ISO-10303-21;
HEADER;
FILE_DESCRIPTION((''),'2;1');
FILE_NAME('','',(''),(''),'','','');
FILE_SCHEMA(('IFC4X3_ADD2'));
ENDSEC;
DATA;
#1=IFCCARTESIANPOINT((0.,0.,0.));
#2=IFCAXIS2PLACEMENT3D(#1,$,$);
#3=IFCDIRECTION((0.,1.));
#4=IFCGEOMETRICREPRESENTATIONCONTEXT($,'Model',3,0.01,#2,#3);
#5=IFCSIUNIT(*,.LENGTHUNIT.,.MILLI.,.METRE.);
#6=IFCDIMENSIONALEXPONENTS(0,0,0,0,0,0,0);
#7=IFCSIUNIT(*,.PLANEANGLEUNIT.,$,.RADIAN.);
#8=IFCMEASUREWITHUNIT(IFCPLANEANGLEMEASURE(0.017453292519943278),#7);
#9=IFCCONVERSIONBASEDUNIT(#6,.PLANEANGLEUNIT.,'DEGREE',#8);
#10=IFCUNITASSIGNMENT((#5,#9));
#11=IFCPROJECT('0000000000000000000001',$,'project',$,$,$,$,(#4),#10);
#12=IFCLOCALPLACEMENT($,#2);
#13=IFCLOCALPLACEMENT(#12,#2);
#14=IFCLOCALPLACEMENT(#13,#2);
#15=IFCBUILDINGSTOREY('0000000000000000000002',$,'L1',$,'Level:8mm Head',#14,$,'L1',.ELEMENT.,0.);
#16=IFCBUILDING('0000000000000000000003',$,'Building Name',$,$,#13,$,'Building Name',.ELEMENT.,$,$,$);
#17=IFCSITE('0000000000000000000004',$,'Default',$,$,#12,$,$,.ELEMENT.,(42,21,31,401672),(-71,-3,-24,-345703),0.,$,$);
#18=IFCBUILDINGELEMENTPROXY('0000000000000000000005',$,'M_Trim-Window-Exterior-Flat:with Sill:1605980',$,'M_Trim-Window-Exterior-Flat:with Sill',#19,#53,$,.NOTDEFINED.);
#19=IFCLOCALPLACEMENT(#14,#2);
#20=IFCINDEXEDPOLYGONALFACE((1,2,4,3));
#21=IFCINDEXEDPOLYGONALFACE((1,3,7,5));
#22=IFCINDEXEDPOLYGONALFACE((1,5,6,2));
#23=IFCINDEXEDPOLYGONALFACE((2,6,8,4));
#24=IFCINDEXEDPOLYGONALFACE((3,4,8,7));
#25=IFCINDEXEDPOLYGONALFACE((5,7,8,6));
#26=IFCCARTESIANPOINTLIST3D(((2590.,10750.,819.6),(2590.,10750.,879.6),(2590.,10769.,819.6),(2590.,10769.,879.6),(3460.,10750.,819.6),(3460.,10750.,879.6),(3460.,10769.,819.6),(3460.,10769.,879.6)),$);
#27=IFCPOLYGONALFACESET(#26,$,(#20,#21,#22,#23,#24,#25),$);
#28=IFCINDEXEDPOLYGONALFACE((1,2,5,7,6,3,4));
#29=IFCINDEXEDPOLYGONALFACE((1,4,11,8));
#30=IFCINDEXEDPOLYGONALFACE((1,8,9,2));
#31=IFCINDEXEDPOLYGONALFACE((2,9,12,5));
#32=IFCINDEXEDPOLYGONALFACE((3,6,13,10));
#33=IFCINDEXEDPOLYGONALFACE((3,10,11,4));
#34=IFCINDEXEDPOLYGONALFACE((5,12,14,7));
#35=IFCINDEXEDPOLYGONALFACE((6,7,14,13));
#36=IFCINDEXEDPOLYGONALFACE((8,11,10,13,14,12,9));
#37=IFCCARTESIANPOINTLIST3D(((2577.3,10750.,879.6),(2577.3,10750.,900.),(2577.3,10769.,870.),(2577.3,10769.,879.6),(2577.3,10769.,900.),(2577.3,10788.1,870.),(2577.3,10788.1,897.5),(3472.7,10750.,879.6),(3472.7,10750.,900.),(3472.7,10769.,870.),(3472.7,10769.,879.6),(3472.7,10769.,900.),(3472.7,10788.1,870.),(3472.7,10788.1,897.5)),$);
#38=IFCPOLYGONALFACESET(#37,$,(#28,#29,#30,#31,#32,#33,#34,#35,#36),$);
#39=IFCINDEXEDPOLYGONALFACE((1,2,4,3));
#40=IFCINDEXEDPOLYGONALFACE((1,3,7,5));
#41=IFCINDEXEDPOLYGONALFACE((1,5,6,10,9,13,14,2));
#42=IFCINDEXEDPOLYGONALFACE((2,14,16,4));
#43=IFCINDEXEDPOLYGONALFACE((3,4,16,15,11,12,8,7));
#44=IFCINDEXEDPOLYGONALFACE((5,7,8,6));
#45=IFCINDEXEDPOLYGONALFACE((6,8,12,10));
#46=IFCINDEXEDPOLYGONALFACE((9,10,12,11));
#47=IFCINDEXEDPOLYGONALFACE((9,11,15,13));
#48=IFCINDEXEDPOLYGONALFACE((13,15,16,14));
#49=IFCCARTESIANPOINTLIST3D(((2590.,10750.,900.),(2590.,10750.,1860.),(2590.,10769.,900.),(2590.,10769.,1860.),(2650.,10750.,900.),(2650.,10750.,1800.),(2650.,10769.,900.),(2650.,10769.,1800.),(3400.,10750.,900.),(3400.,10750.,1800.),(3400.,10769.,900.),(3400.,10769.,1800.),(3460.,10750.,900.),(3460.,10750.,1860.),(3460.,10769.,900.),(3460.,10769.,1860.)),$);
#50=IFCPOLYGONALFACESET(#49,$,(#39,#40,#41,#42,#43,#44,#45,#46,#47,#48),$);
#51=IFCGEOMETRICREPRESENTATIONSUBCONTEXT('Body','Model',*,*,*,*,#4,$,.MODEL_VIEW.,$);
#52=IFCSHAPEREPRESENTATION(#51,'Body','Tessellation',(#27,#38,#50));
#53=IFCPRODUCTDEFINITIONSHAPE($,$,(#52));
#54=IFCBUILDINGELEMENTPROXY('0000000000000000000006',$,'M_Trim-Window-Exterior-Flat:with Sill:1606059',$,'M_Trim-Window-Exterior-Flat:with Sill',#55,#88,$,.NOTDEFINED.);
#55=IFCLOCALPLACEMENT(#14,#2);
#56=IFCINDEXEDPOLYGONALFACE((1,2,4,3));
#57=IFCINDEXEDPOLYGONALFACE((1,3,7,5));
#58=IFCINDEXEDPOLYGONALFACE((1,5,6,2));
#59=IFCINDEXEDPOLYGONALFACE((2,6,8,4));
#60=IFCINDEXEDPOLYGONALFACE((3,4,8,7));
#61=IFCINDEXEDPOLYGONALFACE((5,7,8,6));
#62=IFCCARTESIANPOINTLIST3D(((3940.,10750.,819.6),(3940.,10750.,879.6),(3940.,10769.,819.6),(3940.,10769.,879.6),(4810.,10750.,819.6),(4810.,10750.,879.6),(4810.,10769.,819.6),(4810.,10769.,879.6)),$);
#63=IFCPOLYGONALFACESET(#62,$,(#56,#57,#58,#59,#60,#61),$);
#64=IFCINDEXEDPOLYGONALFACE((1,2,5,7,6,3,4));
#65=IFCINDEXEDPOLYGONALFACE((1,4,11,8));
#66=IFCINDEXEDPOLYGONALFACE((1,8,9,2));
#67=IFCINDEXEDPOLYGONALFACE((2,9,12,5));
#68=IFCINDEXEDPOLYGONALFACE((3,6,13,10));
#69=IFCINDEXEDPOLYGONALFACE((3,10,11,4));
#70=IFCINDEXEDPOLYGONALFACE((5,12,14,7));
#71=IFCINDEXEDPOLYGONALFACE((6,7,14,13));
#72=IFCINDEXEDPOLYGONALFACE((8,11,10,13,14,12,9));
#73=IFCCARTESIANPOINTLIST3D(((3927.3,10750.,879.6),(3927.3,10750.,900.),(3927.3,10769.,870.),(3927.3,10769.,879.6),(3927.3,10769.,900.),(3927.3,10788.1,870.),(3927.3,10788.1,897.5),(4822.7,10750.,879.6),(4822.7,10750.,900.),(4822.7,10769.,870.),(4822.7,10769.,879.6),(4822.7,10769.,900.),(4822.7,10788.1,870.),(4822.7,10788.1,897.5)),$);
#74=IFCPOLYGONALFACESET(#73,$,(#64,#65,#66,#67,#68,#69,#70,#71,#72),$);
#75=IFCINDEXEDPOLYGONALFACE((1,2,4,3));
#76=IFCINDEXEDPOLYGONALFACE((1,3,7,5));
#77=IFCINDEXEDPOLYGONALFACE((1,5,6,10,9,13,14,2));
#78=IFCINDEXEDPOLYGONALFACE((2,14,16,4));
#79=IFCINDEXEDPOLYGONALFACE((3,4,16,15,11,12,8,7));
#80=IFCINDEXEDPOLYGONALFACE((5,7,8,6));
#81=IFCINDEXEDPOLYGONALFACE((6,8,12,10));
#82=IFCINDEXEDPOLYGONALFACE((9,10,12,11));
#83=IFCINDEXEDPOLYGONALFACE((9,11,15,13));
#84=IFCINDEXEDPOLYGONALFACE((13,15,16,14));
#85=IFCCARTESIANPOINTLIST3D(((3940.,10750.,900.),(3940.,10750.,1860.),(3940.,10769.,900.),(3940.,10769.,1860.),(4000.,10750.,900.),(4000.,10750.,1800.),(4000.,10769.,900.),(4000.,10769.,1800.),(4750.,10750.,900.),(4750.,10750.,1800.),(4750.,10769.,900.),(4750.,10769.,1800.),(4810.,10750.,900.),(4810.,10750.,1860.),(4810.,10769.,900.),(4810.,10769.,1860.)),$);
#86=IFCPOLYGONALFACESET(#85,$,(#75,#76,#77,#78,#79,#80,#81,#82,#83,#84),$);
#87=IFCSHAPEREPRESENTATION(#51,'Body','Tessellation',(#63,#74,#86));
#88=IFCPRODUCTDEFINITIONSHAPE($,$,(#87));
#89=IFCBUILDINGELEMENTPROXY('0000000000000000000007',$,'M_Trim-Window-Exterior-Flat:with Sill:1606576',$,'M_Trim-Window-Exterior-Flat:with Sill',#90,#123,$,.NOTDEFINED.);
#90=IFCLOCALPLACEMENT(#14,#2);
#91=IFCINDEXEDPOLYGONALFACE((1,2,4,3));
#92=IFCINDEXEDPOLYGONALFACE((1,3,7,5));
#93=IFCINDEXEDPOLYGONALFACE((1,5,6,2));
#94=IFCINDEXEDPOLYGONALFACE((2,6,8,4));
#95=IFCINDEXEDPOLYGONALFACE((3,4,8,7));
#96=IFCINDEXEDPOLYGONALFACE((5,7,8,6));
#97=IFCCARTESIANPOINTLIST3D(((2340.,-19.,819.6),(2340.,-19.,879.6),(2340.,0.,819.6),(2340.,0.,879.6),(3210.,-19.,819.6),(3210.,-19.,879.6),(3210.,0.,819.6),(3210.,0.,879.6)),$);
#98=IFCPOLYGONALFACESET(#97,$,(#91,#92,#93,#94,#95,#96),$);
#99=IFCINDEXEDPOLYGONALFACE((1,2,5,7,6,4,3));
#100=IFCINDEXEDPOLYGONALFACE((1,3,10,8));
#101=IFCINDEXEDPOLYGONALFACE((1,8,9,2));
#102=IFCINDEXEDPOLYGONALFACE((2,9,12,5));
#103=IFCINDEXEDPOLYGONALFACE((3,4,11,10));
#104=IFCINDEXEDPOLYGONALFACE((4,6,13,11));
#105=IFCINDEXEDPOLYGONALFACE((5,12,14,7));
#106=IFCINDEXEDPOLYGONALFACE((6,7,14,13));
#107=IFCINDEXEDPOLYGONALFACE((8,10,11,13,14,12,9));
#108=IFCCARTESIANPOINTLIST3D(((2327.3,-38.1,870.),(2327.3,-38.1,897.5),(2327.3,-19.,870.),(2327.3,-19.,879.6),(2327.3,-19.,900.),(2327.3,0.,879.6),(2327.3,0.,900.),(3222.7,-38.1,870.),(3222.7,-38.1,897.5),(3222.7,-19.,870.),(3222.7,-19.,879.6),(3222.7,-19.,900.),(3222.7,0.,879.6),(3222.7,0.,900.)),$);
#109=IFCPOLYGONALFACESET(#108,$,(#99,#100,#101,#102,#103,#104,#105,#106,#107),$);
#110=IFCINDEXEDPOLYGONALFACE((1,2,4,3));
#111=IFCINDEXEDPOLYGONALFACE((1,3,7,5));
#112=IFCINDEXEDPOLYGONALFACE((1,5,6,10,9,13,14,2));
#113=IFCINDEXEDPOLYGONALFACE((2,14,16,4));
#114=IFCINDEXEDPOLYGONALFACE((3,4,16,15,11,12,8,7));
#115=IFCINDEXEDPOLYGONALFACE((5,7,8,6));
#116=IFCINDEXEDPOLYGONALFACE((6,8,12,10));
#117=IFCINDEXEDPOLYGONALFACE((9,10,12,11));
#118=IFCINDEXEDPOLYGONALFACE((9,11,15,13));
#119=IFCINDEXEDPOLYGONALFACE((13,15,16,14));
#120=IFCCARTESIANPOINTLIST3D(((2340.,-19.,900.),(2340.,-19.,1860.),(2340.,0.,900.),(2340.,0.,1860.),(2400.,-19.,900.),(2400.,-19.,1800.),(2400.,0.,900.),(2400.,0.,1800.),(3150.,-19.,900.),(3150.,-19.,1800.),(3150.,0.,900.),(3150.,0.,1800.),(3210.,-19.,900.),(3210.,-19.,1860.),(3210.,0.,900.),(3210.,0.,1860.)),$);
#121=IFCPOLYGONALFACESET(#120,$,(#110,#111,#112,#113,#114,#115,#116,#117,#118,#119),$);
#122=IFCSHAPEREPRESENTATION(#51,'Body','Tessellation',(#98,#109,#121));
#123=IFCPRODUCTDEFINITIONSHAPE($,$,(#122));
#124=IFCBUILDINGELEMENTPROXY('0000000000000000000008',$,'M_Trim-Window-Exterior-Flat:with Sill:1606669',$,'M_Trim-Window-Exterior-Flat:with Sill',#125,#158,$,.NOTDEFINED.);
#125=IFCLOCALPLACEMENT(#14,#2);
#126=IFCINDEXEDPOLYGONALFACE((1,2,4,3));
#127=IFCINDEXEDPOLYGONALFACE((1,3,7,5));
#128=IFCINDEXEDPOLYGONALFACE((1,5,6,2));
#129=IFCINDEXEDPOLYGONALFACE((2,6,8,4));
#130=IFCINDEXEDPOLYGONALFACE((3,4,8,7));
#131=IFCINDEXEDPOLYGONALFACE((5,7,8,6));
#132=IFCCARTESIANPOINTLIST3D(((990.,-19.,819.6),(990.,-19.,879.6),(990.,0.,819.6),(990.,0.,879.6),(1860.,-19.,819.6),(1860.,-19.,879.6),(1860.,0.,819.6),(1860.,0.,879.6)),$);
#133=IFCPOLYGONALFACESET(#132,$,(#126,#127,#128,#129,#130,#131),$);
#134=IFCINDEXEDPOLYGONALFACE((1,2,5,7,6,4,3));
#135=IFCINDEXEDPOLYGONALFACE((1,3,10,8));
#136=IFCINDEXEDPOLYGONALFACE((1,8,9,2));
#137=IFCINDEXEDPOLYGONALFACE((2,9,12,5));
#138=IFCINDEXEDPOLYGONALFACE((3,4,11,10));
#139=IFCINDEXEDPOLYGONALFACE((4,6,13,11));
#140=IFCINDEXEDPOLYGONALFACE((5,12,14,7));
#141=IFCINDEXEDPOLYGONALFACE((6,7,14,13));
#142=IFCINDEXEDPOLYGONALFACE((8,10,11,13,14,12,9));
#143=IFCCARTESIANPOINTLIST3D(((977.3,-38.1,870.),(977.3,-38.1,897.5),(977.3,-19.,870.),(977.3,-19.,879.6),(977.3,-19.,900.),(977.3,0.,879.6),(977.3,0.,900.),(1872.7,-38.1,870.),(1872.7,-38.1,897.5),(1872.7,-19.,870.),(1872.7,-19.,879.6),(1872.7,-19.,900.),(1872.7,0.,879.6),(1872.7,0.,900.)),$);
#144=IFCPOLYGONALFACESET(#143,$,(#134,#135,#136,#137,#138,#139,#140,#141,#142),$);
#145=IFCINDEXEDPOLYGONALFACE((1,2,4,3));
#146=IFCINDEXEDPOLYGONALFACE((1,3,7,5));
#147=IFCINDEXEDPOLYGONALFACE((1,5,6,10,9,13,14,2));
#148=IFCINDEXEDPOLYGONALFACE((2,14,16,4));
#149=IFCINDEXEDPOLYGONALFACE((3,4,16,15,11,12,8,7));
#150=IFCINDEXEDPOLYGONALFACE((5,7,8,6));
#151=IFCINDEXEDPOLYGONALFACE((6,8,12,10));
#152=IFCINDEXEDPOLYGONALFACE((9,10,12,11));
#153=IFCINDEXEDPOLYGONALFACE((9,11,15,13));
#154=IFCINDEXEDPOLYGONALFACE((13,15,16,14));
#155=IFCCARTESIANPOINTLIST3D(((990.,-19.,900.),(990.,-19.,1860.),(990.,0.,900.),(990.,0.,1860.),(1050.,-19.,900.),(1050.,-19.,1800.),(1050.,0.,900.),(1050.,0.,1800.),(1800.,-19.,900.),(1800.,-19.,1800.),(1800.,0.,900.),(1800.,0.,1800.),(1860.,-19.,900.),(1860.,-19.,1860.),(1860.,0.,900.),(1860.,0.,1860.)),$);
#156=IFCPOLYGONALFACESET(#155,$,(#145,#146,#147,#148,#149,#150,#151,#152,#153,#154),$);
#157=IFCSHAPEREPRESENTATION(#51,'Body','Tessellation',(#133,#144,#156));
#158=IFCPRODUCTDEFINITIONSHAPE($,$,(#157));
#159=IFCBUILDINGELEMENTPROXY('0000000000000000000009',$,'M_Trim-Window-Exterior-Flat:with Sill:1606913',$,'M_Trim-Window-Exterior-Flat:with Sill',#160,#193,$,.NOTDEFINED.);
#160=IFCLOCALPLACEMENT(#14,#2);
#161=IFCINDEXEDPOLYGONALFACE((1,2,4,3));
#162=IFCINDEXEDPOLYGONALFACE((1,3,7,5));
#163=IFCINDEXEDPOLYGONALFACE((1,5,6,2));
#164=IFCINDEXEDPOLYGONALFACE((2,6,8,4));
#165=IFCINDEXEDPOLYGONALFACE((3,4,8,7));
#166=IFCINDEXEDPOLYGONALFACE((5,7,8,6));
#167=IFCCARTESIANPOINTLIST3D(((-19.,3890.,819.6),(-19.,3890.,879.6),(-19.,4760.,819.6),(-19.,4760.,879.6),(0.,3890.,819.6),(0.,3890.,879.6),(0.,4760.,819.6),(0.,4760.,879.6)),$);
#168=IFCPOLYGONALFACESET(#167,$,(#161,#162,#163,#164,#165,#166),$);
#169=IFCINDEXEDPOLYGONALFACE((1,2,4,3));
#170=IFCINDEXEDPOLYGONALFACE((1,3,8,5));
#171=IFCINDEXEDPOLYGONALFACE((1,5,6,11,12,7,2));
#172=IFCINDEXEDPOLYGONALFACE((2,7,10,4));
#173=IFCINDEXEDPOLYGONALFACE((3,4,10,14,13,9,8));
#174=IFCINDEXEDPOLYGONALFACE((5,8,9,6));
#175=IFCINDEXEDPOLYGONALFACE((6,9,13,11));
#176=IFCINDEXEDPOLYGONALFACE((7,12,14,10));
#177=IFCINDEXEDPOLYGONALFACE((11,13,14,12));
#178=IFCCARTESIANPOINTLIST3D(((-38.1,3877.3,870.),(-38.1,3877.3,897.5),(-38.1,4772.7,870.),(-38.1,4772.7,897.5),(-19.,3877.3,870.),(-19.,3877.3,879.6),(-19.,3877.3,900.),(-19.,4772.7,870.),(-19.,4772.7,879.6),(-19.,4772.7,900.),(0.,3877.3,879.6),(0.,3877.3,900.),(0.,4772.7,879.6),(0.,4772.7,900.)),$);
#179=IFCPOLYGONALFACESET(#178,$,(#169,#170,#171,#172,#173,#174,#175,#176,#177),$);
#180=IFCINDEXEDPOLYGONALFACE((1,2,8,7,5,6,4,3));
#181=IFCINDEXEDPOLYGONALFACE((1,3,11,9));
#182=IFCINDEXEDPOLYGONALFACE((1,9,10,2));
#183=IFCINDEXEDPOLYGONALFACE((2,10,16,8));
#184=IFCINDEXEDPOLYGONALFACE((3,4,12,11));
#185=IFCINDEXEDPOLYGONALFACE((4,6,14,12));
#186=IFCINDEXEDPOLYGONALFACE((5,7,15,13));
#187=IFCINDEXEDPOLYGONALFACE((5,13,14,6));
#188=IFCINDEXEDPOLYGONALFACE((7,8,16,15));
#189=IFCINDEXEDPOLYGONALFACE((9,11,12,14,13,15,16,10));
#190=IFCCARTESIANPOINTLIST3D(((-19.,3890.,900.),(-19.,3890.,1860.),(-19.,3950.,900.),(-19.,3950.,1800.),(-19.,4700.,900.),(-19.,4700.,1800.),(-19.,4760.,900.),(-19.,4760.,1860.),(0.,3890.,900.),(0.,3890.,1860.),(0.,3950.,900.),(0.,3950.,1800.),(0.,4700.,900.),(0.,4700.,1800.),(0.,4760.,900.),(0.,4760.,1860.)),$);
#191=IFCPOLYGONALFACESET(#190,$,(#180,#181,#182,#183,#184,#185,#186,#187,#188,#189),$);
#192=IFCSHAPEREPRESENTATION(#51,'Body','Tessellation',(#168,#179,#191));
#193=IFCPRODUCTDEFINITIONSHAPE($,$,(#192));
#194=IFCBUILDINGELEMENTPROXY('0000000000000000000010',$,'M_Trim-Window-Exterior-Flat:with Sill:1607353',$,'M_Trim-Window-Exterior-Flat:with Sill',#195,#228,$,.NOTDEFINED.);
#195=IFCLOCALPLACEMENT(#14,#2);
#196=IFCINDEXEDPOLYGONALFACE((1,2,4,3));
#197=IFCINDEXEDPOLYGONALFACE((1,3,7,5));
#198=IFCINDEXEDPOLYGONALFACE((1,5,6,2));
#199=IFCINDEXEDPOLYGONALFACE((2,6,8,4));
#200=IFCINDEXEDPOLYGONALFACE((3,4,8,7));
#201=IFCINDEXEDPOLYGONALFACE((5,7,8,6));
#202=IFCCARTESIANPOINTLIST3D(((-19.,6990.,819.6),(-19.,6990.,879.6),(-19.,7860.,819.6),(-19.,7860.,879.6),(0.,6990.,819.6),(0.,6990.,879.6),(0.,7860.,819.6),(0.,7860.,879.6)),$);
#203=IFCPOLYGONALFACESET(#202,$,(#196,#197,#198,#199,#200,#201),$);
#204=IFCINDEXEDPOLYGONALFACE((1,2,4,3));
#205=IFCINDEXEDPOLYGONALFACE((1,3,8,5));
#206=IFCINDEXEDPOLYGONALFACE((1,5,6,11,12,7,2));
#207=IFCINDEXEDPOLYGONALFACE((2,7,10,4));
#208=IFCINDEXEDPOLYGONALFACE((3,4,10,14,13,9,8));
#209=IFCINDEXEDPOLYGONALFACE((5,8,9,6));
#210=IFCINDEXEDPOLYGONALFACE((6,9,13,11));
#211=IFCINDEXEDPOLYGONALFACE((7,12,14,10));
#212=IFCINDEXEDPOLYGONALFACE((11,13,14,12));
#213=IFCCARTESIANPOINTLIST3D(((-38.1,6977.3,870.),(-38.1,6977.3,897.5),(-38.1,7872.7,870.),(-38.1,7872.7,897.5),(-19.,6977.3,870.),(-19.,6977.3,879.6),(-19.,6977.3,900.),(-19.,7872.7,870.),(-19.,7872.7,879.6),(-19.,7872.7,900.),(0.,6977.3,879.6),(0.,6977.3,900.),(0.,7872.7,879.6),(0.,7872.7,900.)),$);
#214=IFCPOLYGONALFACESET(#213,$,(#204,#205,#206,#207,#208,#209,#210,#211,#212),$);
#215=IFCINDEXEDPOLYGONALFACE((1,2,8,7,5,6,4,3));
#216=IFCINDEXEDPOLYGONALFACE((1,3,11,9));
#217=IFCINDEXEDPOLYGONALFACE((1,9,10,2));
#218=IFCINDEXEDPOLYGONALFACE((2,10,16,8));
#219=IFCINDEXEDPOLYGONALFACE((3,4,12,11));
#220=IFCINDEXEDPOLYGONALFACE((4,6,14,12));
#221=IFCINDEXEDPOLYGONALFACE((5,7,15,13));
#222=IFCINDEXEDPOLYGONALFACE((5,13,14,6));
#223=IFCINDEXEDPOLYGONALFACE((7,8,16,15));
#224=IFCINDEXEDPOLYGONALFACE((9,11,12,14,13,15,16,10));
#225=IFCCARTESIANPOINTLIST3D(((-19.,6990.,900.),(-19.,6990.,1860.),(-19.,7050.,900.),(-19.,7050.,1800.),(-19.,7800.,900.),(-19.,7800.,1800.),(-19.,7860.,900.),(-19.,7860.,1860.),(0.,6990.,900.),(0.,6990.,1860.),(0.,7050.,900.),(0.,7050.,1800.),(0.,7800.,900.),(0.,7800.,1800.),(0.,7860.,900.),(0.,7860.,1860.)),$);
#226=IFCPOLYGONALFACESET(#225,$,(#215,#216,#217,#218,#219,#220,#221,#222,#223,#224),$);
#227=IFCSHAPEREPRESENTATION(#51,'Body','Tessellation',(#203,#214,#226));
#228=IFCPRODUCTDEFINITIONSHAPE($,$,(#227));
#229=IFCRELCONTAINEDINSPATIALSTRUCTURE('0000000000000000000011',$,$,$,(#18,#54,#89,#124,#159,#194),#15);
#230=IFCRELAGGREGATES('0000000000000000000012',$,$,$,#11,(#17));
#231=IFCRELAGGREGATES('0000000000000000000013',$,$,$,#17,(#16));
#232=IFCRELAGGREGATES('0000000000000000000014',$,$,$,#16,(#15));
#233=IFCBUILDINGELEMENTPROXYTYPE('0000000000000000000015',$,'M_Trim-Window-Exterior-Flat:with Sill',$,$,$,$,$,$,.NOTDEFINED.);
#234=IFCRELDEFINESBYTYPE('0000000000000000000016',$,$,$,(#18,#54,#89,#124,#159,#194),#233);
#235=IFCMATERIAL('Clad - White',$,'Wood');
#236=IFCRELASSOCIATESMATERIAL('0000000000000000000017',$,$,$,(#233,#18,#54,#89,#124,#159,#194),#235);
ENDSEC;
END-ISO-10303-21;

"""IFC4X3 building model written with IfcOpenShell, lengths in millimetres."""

from ifc_helpers import new_model, entity, si_unit, converted_unit, direction, frame, frame_2d, origin, place, context, subcontext, project, spatial, polyline, rectangle, outline, extrude, source, transform, mapped, material, type_object, type_shapes, element, save


model = new_model("IFC4X3")

# Units and contexts
model_context = context("Model", 3, precision=0.01, world=origin(), true_north=direction((0.0, 1.0)))
body_context = subcontext(model_context, "Body", "Model", "MODEL_VIEW")
ifc_project = project(units=[si_unit("LENGTHUNIT", "METRE", prefix="MILLI"), converted_unit("PLANEANGLEUNIT", "DEGREE", entity("IfcPlaneAngleMeasure", 0.017453292519943278), si_unit("PLANEANGLEUNIT", "RADIAN"), dimensions=[0, 0, 0, 0, 0, 0, 0])], contexts=[model_context])

# Site, building, storey
site_placement = place(None, origin())
site = spatial("IfcSite", under=ifc_project, at=site_placement, Name="Default", CompositionType="ELEMENT", RefLatitude=(42, 21, 31, 401672), RefLongitude=(-71, -3, -24, -345703), RefElevation=0.0)
building_placement = place(site_placement, origin())
building = spatial("IfcBuilding", under=site, at=building_placement, Name="Building Name", LongName="Building Name", CompositionType="ELEMENT")
storey_placement = place(building_placement, origin())
storey = spatial("IfcBuildingStorey", under=building, at=storey_placement, Name="L1", ObjectType="Level:8mm Head", LongName="L1", CompositionType="ELEMENT", Elevation=0.0)

# Building element proxies
ifc_material_1 = material(Name="Clad - White", Category="Wood")
building_element_proxy_type_1 = type_object("IfcBuildingElementProxyType", Name="M_Trim-Window-Exterior-Flat:with Sill", PredefinedType="NOTDEFINED", material=ifc_material_1)
shared_shape_1 = source(origin(), body_context, "Body", "SweptSolid", [
    extrude(rectangle(XDim=870.0, YDim=60.0, at=frame_2d((0.0, 0.0), x_axis=(1.0, 0.0))), frame((0.0, -950.4, 0.0), z_axis=(0.0, 0.0, 1.0), x_axis=(-1.0, 0.0, 0.0)), (0.0, 0.0, 1.0), 19.0),
    extrude(outline(polyline([(-19.0, -15.2), (0.0, -15.2), (0.0, -5.7), (19.0, -5.7), (19.0, 14.8), (0.0, 14.8), (-19.0, 12.3), (-19.0, -15.2)])), frame((-447.7, -914.8, 19.0), z_axis=(1.0, 0.0, 0.0), x_axis=(0.0, 0.0, -1.0)), (0.0, 0.0, 1.0), 895.4),
    extrude(outline(polyline([(-495.0, -435.0), (465.0, -435.0), (465.0, -375.0), (-435.0, -375.0), (-435.0, 375.0), (465.0, 375.0), (465.0, 435.0), (-495.0, 435.0), (-495.0, -435.0)])), frame((0.0, -435.0, 0.0), z_axis=(0.0, 0.0, 1.0), x_axis=(0.0, -1.0, 0.0)), (0.0, 0.0, 1.0), 19.0),
])
type_shapes(building_element_proxy_type_1, [shared_shape_1])
for number, where, z_axis, x_axis, name in (
    (1, (3025.0, 10750.0, 1800.0), (0.0, 1.0, 0.0), (-1.0, 0.0, 0.0), "M_Trim-Window-Exterior-Flat:with Sill:1605980"),
    (2, (4375.0, 10750.0, 1800.0), (0.0, 1.0, 0.0), (-1.0, 0.0, 0.0), "M_Trim-Window-Exterior-Flat:with Sill:1606059"),
    (3, (2775.0, 0.0, 1800.0), (0.0, -1.0, 0.0), (1.0, 0.0, 0.0), "M_Trim-Window-Exterior-Flat:with Sill:1606576"),
    (4, (1425.0, 0.0, 1800.0), (0.0, -1.0, 0.0), (1.0, 0.0, 0.0), "M_Trim-Window-Exterior-Flat:with Sill:1606669"),
    (5, (0.0, 4325.0, 1800.0), (-1.0, 0.0, 0.0), (0.0, -1.0, 0.0), "M_Trim-Window-Exterior-Flat:with Sill:1606913"),
    (6, (0.0, 7425.0, 1800.0), (-1.0, 0.0, 0.0), (0.0, -1.0, 0.0), "M_Trim-Window-Exterior-Flat:with Sill:1607353"),
):
    element("IfcBuildingElementProxy", number, at=place(storey_placement, frame(where, z_axis=z_axis, x_axis=x_axis)), inside=storey, type_object=building_element_proxy_type_1, material=ifc_material_1, Name=name, ObjectType="M_Trim-Window-Exterior-Flat:with Sill", PredefinedType="NOTDEFINED", context=body_context, shape_type="MappedRepresentation", body=[
        mapped(shared_shape_1, transform((0.0, 0.0, 0.0), scale=1.0)),
    ])

save(model, "model.ifc")
